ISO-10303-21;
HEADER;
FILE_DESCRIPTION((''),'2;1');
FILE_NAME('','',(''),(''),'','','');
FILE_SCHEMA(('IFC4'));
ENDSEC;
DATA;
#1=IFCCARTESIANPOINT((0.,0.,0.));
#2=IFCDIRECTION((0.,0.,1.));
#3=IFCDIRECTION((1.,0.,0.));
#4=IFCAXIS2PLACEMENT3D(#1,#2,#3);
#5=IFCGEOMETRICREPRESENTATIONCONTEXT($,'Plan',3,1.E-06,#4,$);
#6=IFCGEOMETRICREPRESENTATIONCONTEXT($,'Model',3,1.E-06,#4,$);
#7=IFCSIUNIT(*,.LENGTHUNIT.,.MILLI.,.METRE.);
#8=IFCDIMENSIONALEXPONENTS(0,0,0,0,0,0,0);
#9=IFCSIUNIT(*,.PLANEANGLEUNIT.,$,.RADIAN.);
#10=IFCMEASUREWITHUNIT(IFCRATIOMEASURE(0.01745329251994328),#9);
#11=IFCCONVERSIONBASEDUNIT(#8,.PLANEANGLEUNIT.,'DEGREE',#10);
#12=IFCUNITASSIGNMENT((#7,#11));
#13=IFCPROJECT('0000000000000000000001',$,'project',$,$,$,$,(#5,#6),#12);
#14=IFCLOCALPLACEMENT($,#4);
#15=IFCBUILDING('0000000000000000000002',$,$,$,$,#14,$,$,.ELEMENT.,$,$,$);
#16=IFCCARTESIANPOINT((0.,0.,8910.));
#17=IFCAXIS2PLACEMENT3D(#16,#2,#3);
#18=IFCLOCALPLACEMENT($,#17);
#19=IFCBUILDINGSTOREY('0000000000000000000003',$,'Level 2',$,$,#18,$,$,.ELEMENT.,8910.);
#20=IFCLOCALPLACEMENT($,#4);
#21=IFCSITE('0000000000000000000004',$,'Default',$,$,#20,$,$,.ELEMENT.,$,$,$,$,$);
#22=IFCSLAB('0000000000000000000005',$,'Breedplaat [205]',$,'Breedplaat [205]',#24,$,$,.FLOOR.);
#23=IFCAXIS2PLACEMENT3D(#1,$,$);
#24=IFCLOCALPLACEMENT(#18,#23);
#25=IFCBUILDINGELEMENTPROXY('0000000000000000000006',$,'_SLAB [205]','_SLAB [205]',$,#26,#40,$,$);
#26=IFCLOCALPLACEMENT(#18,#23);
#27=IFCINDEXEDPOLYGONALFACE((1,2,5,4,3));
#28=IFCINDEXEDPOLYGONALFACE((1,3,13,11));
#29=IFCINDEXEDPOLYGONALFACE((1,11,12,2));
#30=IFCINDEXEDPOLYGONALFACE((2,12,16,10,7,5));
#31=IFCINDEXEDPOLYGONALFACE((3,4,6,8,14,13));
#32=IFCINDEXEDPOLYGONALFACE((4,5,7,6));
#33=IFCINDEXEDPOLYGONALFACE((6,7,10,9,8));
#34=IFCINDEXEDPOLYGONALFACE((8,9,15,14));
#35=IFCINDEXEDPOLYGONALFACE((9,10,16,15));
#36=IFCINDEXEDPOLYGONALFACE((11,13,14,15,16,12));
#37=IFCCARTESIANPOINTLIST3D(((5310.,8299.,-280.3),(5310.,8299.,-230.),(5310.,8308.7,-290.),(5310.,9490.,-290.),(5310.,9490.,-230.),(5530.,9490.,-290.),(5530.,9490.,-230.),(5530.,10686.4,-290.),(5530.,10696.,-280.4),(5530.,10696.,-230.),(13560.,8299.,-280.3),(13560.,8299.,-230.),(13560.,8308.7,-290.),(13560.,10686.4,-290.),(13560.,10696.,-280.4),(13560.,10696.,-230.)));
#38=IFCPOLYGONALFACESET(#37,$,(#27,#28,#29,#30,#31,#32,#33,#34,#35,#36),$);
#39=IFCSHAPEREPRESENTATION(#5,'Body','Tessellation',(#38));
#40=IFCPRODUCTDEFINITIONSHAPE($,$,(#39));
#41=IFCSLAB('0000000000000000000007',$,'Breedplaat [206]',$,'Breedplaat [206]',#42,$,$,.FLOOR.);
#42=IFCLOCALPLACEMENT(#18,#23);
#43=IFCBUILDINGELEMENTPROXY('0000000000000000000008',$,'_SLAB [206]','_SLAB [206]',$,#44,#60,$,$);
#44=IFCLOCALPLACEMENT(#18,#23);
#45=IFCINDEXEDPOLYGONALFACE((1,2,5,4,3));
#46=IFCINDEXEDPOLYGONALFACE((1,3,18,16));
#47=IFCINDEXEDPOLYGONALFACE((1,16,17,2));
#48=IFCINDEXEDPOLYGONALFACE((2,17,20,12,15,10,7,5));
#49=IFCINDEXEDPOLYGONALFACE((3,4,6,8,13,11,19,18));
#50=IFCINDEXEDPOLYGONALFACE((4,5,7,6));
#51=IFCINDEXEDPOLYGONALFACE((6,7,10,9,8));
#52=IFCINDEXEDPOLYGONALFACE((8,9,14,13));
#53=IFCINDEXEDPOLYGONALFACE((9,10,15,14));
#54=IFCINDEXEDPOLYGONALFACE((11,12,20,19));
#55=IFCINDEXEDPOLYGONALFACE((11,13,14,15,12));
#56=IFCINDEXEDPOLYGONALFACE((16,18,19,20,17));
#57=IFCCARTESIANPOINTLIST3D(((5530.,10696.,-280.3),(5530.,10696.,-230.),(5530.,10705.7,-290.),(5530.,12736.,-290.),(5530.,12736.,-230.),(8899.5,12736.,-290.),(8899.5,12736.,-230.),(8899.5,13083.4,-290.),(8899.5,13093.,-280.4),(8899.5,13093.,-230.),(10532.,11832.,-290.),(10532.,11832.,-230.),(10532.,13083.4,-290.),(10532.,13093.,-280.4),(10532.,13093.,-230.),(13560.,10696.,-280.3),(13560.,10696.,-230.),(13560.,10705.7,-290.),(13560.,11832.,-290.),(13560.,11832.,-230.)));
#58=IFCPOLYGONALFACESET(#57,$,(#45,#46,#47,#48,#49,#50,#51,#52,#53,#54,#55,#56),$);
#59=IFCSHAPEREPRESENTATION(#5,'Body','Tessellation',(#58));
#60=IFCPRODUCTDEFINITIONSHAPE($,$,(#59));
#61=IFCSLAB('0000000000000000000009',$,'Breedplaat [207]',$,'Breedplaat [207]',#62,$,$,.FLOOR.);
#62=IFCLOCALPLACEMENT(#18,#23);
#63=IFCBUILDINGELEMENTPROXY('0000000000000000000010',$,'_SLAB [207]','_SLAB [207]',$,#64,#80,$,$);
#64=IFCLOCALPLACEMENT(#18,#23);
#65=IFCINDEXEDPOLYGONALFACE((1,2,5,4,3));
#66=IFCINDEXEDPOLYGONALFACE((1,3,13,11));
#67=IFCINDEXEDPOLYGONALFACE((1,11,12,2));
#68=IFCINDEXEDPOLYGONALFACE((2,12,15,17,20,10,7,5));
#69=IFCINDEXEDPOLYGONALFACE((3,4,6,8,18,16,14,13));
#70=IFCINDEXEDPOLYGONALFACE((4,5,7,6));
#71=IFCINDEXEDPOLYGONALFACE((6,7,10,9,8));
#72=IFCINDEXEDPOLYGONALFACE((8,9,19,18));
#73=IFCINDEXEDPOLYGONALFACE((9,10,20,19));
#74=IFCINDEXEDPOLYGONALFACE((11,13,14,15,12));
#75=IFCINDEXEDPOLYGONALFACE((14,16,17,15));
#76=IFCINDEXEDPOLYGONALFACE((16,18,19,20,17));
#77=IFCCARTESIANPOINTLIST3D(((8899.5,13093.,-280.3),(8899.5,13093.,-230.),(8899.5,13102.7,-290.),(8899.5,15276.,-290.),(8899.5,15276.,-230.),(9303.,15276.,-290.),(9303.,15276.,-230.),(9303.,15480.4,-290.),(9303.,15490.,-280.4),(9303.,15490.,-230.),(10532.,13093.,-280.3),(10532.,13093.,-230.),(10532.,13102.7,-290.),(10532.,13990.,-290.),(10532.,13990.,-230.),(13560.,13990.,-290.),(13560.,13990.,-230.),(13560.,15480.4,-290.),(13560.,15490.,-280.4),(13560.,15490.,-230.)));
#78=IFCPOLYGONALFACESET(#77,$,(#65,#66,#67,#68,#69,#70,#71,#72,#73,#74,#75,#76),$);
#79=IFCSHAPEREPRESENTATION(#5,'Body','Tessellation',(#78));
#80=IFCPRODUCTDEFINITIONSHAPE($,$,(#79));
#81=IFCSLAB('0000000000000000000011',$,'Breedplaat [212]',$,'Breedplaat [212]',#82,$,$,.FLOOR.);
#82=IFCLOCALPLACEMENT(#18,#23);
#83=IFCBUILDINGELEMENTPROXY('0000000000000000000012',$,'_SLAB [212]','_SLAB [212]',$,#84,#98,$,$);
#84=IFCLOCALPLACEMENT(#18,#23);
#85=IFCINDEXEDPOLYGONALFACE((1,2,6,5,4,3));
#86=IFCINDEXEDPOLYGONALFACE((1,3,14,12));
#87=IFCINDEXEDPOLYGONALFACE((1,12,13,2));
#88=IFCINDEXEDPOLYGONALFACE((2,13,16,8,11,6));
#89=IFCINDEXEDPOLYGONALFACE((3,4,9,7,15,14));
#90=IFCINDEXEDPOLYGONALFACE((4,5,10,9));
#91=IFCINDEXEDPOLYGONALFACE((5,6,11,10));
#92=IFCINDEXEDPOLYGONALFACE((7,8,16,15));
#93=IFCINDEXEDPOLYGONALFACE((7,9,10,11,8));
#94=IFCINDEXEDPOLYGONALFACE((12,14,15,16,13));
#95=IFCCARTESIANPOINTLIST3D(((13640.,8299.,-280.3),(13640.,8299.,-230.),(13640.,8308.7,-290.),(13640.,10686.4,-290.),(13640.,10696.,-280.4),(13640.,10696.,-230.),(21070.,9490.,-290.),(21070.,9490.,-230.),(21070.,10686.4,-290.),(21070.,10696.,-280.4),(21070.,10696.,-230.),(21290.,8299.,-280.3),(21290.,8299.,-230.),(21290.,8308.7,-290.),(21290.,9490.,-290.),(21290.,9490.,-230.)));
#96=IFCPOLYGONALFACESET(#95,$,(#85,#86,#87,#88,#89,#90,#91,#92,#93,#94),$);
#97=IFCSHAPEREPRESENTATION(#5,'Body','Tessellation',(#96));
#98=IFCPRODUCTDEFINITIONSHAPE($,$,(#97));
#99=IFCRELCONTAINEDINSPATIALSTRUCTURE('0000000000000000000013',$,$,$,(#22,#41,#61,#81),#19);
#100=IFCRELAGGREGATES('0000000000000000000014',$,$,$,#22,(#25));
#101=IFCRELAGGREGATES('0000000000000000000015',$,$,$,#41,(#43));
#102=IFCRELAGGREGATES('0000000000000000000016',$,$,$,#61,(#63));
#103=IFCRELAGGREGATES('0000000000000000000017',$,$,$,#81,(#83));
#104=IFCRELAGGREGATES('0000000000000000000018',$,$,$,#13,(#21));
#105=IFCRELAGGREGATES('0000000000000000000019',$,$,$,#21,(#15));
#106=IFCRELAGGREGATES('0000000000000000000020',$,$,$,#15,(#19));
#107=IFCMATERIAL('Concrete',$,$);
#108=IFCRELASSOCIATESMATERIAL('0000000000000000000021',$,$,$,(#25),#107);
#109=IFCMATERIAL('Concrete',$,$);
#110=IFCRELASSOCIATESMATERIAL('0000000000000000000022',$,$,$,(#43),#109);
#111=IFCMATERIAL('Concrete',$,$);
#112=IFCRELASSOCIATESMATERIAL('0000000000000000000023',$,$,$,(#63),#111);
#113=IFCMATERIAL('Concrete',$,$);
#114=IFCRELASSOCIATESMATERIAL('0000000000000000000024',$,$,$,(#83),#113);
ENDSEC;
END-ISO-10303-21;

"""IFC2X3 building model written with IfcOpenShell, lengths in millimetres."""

from ifc_helpers import new_model, entity, si_unit, converted_unit, frame, origin_with_axes, place, context, project, spatial, polyline, outline, extrude, material, element, aggregate, save


model = new_model("IFC2X3")

# Units and contexts
plan_context = context("Plan", 3, precision=1e-06, world=origin_with_axes())
model_context = context("Model", 3, precision=1e-06, world=origin_with_axes())
ifc_project = project(units=[si_unit("LENGTHUNIT", "METRE", prefix="MILLI"), converted_unit("PLANEANGLEUNIT", "DEGREE", entity("IfcRatioMeasure", 0.01745329251994328), si_unit("PLANEANGLEUNIT", "RADIAN"), dimensions=[0, 0, 0, 0, 0, 0, 0])], contexts=[plan_context, model_context])

# Site, building, storey
site_placement = place(None, origin_with_axes())
site = spatial("IfcSite", under=ifc_project, at=site_placement, Name="Default", CompositionType="ELEMENT")
building_placement = place(None, origin_with_axes())
building = spatial("IfcBuilding", under=site, at=building_placement, CompositionType="ELEMENT")
storey_placement = place(None, frame((0.0, 0.0, 8910.0), z_axis=(0.0, 0.0, 1.0), x_axis=(1.0, 0.0, 0.0)))
storey = spatial("IfcBuildingStorey", under=building, at=storey_placement, Name="Level 2", CompositionType="ELEMENT", Elevation=8910.0)

# Slabs, building element proxies, openings
slab_1_placement = place(None, frame((5310.0, 8299.0, 8620.0), z_axis=(0.0, 0.0, 1.0), x_axis=(1.0, 0.0, 0.0)))
slab_1 = element("IfcSlab", 1, at=slab_1_placement, inside=storey, Name="Breedplaat [205]", ObjectType="Breedplaat [205]", PredefinedType="FLOOR")
ifc_material_1 = material(Name="Concrete")
proxy_1_placement = place(slab_1_placement, origin_with_axes())
proxy_1 = element("IfcBuildingElementProxy", 2, at=proxy_1_placement, material=ifc_material_1, Name="_SLAB [205]", Description="_SLAB [205]", context=plan_context, shape_type="SweptSolid", body=[
    extrude(outline(polyline([(220.0, 2397.0), (220.0, 1191.0), (0.0, 1191.0), (0.0, 0.0), (8250.0, 0.0), (8250.0, 2397.0), (220.0, 2397.0)])), origin_with_axes(), (0.0, 0.0, 1.0), 60.0),
])
opening_1_placement = place(None, frame((5310.0, 8299.0, 8620.0), z_axis=(0.0, 0.0, 1.0), x_axis=(1.0, 0.0, 0.0)))
element("IfcOpeningElement", 3, at=opening_1_placement, cuts=proxy_1, ObjectType="Opening", context=plan_context, shape_type="SweptSolid", body=[
    extrude(outline(polyline([(-0.1, -0.1), (-0.1, 10.0), (10.0, -0.1), (-0.1, -0.1)])), frame((-1.2, -0.1, -0.1), z_axis=(1.0, 0.0, 0.0), x_axis=(0.0, 1.0, 0.0)), (0.0, 0.0, 1.0), 8252.2),
])
opening_2_placement = place(None, frame((5310.0, 8299.0, 8620.0), z_axis=(0.0, 0.0, 1.0), x_axis=(1.0, 0.0, 0.0)))
element("IfcOpeningElement", 4, at=opening_2_placement, cuts=proxy_1, ObjectType="Opening", context=plan_context, shape_type="SweptSolid", body=[
    extrude(outline(polyline([(-0.1, -0.1), (-0.1, 10.0), (10.0, -0.1), (-0.1, -0.1)])), frame((8251.2, 2397.2, -0.1), z_axis=(-1.0, 0.0, 0.0), x_axis=(0.0, -1.0, 0.0)), (0.0, 0.0, 1.0), 8032.2),
])
aggregate(slab_1, [proxy_1])
slab_2_placement = place(None, frame((5530.0, 10696.0, 8620.0), z_axis=(0.0, 0.0, 1.0), x_axis=(1.0, 0.0, 0.0)))
slab_2 = element("IfcSlab", 5, at=slab_2_placement, inside=storey, Name="Breedplaat [206]", ObjectType="Breedplaat [206]", PredefinedType="FLOOR")
ifc_material_2 = material(Name="Concrete")
proxy_2_placement = place(slab_2_placement, origin_with_axes())
proxy_2 = element("IfcBuildingElementProxy", 6, at=proxy_2_placement, material=ifc_material_2, Name="_SLAB [206]", Description="_SLAB [206]", context=plan_context, shape_type="SweptSolid", body=[
    extrude(outline(polyline([(3369.5, 2397.0), (3369.5, 2040.0), (0.0, 2040.0), (0.0, 0.0), (8030.0, 0.0), (8030.0, 1136.0), (5002.0, 1136.0), (5002.0, 2397.0), (3369.5, 2397.0)])), origin_with_axes(), (0.0, 0.0, 1.0), 60.0),
])
opening_3_placement = place(None, frame((5530.0, 10696.0, 8620.0), z_axis=(0.0, 0.0, 1.0), x_axis=(1.0, 0.0, 0.0)))
element("IfcOpeningElement", 7, at=opening_3_placement, cuts=proxy_2, ObjectType="Opening", context=plan_context, shape_type="SweptSolid", body=[
    extrude(outline(polyline([(-0.1, -0.1), (-0.1, 10.0), (10.0, -0.1), (-0.1, -0.1)])), frame((-1.2, -0.1, -0.1), z_axis=(1.0, 0.0, 0.0), x_axis=(0.0, 1.0, 0.0)), (0.0, 0.0, 1.0), 8032.2),
])
opening_4_placement = place(None, frame((5530.0, 10696.0, 8620.0), z_axis=(0.0, 0.0, 1.0), x_axis=(1.0, 0.0, 0.0)))
element("IfcOpeningElement", 8, at=opening_4_placement, cuts=proxy_2, ObjectType="Opening", context=plan_context, shape_type="SweptSolid", body=[
    extrude(outline(polyline([(-0.1, -0.1), (-0.1, 10.0), (10.0, -0.1), (-0.1, -0.1)])), frame((5003.2, 2397.2, -0.1), z_axis=(-1.0, 0.0, 0.0), x_axis=(0.0, -1.0, 0.0)), (0.0, 0.0, 1.0), 1634.7),
])
aggregate(slab_2, [proxy_2])
slab_3_placement = place(None, frame((8899.5, 13093.0, 8620.0), z_axis=(0.0, 0.0, 1.0), x_axis=(1.0, 0.0, 0.0)))
slab_3 = element("IfcSlab", 9, at=slab_3_placement, inside=storey, Name="Breedplaat [207]", ObjectType="Breedplaat [207]", PredefinedType="FLOOR")
ifc_material_3 = material(Name="Concrete")
proxy_3_placement = place(slab_3_placement, origin_with_axes())
proxy_3 = element("IfcBuildingElementProxy", 10, at=proxy_3_placement, material=ifc_material_3, Name="_SLAB [207]", Description="_SLAB [207]", context=plan_context, shape_type="SweptSolid", body=[
    extrude(outline(polyline([(1632.5, 0.0), (1632.5, 897.0), (4660.6, 897.0), (4660.6, 2397.0), (403.6, 2397.0), (403.6, 2183.0), (0.0, 2183.0), (0.0, 0.0), (1632.5, 0.0)])), origin_with_axes(), (0.0, 0.0, 1.0), 60.0),
])
opening_5_placement = place(None, frame((8899.5, 13093.0, 8620.0), z_axis=(0.0, 0.0, 1.0), x_axis=(1.0, 0.0, 0.0)))
element("IfcOpeningElement", 11, at=opening_5_placement, cuts=proxy_3, ObjectType="Opening", context=plan_context, shape_type="SweptSolid", body=[
    extrude(outline(polyline([(-0.1, -0.1), (-0.1, 10.0), (10.0, -0.1), (-0.1, -0.1)])), frame((-1.2, -0.1, -0.1), z_axis=(1.0, 0.0, 0.0), x_axis=(0.0, 1.0, 0.0)), (0.0, 0.0, 1.0), 1634.8),
])
opening_6_placement = place(None, frame((8899.5, 13093.0, 8620.0), z_axis=(0.0, 0.0, 1.0), x_axis=(1.0, 0.0, 0.0)))
element("IfcOpeningElement", 12, at=opening_6_placement, cuts=proxy_3, ObjectType="Opening", context=plan_context, shape_type="SweptSolid", body=[
    extrude(outline(polyline([(-0.1, -0.1), (-0.1, 10.0), (10.0, -0.1), (-0.1, -0.1)])), frame((4661.8, 2397.2, -0.1), z_axis=(-1.0, 0.0, 0.0), x_axis=(0.0, -1.0, 0.0)), (0.0, 0.0, 1.0), 4259.2),
])
aggregate(slab_3, [proxy_3])

# Slab, building element proxy, openings
slab_4_placement = place(None, frame((13640.0, 8299.0, 8620.0), z_axis=(0.0, 0.0, 1.0), x_axis=(1.0, 0.0, 0.0)))
slab_4 = element("IfcSlab", 13, at=slab_4_placement, inside=storey, Name="Breedplaat [212]", ObjectType="Breedplaat [212]", PredefinedType="FLOOR")
ifc_material_4 = material(Name="Concrete")
proxy_4_placement = place(slab_4_placement, origin_with_axes())
proxy_4 = element("IfcBuildingElementProxy", 14, at=proxy_4_placement, material=ifc_material_4, Name="_SLAB [212]", Description="_SLAB [212]", context=plan_context, shape_type="SweptSolid", body=[
    extrude(outline(polyline([(7650.0, 1191.0), (7430.0, 1191.0), (7430.0, 2397.0), (0.0, 2397.0), (0.0, 0.0), (7650.0, 0.0), (7650.0, 1191.0)])), origin_with_axes(), (0.0, 0.0, 1.0), 60.0),
])
opening_7_placement = place(None, frame((13640.0, 8299.0, 8620.0), z_axis=(0.0, 0.0, 1.0), x_axis=(1.0, 0.0, 0.0)))
element("IfcOpeningElement", 15, at=opening_7_placement, cuts=proxy_4, ObjectType="Opening", context=plan_context, shape_type="SweptSolid", body=[
    extrude(outline(polyline([(-0.1, -0.1), (-0.1, 10.0), (10.0, -0.1), (-0.1, -0.1)])), frame((-1.2, -0.1, -0.1), z_axis=(1.0, 0.0, 0.0), x_axis=(0.0, 1.0, 0.0)), (0.0, 0.0, 1.0), 7652.2),
])
opening_8_placement = place(None, frame((13640.0, 8299.0, 8620.0), z_axis=(0.0, 0.0, 1.0), x_axis=(1.0, 0.0, 0.0)))
element("IfcOpeningElement", 16, at=opening_8_placement, cuts=proxy_4, ObjectType="Opening", context=plan_context, shape_type="SweptSolid", body=[
    extrude(outline(polyline([(-0.1, -0.1), (-0.1, 10.0), (10.0, -0.1), (-0.1, -0.1)])), frame((7431.2, 2397.2, -0.1), z_axis=(-1.0, 0.0, 0.0), x_axis=(0.0, -1.0, 0.0)), (0.0, 0.0, 1.0), 7432.2),
])
aggregate(slab_4, [proxy_4])

save(model, "model.ifc")
